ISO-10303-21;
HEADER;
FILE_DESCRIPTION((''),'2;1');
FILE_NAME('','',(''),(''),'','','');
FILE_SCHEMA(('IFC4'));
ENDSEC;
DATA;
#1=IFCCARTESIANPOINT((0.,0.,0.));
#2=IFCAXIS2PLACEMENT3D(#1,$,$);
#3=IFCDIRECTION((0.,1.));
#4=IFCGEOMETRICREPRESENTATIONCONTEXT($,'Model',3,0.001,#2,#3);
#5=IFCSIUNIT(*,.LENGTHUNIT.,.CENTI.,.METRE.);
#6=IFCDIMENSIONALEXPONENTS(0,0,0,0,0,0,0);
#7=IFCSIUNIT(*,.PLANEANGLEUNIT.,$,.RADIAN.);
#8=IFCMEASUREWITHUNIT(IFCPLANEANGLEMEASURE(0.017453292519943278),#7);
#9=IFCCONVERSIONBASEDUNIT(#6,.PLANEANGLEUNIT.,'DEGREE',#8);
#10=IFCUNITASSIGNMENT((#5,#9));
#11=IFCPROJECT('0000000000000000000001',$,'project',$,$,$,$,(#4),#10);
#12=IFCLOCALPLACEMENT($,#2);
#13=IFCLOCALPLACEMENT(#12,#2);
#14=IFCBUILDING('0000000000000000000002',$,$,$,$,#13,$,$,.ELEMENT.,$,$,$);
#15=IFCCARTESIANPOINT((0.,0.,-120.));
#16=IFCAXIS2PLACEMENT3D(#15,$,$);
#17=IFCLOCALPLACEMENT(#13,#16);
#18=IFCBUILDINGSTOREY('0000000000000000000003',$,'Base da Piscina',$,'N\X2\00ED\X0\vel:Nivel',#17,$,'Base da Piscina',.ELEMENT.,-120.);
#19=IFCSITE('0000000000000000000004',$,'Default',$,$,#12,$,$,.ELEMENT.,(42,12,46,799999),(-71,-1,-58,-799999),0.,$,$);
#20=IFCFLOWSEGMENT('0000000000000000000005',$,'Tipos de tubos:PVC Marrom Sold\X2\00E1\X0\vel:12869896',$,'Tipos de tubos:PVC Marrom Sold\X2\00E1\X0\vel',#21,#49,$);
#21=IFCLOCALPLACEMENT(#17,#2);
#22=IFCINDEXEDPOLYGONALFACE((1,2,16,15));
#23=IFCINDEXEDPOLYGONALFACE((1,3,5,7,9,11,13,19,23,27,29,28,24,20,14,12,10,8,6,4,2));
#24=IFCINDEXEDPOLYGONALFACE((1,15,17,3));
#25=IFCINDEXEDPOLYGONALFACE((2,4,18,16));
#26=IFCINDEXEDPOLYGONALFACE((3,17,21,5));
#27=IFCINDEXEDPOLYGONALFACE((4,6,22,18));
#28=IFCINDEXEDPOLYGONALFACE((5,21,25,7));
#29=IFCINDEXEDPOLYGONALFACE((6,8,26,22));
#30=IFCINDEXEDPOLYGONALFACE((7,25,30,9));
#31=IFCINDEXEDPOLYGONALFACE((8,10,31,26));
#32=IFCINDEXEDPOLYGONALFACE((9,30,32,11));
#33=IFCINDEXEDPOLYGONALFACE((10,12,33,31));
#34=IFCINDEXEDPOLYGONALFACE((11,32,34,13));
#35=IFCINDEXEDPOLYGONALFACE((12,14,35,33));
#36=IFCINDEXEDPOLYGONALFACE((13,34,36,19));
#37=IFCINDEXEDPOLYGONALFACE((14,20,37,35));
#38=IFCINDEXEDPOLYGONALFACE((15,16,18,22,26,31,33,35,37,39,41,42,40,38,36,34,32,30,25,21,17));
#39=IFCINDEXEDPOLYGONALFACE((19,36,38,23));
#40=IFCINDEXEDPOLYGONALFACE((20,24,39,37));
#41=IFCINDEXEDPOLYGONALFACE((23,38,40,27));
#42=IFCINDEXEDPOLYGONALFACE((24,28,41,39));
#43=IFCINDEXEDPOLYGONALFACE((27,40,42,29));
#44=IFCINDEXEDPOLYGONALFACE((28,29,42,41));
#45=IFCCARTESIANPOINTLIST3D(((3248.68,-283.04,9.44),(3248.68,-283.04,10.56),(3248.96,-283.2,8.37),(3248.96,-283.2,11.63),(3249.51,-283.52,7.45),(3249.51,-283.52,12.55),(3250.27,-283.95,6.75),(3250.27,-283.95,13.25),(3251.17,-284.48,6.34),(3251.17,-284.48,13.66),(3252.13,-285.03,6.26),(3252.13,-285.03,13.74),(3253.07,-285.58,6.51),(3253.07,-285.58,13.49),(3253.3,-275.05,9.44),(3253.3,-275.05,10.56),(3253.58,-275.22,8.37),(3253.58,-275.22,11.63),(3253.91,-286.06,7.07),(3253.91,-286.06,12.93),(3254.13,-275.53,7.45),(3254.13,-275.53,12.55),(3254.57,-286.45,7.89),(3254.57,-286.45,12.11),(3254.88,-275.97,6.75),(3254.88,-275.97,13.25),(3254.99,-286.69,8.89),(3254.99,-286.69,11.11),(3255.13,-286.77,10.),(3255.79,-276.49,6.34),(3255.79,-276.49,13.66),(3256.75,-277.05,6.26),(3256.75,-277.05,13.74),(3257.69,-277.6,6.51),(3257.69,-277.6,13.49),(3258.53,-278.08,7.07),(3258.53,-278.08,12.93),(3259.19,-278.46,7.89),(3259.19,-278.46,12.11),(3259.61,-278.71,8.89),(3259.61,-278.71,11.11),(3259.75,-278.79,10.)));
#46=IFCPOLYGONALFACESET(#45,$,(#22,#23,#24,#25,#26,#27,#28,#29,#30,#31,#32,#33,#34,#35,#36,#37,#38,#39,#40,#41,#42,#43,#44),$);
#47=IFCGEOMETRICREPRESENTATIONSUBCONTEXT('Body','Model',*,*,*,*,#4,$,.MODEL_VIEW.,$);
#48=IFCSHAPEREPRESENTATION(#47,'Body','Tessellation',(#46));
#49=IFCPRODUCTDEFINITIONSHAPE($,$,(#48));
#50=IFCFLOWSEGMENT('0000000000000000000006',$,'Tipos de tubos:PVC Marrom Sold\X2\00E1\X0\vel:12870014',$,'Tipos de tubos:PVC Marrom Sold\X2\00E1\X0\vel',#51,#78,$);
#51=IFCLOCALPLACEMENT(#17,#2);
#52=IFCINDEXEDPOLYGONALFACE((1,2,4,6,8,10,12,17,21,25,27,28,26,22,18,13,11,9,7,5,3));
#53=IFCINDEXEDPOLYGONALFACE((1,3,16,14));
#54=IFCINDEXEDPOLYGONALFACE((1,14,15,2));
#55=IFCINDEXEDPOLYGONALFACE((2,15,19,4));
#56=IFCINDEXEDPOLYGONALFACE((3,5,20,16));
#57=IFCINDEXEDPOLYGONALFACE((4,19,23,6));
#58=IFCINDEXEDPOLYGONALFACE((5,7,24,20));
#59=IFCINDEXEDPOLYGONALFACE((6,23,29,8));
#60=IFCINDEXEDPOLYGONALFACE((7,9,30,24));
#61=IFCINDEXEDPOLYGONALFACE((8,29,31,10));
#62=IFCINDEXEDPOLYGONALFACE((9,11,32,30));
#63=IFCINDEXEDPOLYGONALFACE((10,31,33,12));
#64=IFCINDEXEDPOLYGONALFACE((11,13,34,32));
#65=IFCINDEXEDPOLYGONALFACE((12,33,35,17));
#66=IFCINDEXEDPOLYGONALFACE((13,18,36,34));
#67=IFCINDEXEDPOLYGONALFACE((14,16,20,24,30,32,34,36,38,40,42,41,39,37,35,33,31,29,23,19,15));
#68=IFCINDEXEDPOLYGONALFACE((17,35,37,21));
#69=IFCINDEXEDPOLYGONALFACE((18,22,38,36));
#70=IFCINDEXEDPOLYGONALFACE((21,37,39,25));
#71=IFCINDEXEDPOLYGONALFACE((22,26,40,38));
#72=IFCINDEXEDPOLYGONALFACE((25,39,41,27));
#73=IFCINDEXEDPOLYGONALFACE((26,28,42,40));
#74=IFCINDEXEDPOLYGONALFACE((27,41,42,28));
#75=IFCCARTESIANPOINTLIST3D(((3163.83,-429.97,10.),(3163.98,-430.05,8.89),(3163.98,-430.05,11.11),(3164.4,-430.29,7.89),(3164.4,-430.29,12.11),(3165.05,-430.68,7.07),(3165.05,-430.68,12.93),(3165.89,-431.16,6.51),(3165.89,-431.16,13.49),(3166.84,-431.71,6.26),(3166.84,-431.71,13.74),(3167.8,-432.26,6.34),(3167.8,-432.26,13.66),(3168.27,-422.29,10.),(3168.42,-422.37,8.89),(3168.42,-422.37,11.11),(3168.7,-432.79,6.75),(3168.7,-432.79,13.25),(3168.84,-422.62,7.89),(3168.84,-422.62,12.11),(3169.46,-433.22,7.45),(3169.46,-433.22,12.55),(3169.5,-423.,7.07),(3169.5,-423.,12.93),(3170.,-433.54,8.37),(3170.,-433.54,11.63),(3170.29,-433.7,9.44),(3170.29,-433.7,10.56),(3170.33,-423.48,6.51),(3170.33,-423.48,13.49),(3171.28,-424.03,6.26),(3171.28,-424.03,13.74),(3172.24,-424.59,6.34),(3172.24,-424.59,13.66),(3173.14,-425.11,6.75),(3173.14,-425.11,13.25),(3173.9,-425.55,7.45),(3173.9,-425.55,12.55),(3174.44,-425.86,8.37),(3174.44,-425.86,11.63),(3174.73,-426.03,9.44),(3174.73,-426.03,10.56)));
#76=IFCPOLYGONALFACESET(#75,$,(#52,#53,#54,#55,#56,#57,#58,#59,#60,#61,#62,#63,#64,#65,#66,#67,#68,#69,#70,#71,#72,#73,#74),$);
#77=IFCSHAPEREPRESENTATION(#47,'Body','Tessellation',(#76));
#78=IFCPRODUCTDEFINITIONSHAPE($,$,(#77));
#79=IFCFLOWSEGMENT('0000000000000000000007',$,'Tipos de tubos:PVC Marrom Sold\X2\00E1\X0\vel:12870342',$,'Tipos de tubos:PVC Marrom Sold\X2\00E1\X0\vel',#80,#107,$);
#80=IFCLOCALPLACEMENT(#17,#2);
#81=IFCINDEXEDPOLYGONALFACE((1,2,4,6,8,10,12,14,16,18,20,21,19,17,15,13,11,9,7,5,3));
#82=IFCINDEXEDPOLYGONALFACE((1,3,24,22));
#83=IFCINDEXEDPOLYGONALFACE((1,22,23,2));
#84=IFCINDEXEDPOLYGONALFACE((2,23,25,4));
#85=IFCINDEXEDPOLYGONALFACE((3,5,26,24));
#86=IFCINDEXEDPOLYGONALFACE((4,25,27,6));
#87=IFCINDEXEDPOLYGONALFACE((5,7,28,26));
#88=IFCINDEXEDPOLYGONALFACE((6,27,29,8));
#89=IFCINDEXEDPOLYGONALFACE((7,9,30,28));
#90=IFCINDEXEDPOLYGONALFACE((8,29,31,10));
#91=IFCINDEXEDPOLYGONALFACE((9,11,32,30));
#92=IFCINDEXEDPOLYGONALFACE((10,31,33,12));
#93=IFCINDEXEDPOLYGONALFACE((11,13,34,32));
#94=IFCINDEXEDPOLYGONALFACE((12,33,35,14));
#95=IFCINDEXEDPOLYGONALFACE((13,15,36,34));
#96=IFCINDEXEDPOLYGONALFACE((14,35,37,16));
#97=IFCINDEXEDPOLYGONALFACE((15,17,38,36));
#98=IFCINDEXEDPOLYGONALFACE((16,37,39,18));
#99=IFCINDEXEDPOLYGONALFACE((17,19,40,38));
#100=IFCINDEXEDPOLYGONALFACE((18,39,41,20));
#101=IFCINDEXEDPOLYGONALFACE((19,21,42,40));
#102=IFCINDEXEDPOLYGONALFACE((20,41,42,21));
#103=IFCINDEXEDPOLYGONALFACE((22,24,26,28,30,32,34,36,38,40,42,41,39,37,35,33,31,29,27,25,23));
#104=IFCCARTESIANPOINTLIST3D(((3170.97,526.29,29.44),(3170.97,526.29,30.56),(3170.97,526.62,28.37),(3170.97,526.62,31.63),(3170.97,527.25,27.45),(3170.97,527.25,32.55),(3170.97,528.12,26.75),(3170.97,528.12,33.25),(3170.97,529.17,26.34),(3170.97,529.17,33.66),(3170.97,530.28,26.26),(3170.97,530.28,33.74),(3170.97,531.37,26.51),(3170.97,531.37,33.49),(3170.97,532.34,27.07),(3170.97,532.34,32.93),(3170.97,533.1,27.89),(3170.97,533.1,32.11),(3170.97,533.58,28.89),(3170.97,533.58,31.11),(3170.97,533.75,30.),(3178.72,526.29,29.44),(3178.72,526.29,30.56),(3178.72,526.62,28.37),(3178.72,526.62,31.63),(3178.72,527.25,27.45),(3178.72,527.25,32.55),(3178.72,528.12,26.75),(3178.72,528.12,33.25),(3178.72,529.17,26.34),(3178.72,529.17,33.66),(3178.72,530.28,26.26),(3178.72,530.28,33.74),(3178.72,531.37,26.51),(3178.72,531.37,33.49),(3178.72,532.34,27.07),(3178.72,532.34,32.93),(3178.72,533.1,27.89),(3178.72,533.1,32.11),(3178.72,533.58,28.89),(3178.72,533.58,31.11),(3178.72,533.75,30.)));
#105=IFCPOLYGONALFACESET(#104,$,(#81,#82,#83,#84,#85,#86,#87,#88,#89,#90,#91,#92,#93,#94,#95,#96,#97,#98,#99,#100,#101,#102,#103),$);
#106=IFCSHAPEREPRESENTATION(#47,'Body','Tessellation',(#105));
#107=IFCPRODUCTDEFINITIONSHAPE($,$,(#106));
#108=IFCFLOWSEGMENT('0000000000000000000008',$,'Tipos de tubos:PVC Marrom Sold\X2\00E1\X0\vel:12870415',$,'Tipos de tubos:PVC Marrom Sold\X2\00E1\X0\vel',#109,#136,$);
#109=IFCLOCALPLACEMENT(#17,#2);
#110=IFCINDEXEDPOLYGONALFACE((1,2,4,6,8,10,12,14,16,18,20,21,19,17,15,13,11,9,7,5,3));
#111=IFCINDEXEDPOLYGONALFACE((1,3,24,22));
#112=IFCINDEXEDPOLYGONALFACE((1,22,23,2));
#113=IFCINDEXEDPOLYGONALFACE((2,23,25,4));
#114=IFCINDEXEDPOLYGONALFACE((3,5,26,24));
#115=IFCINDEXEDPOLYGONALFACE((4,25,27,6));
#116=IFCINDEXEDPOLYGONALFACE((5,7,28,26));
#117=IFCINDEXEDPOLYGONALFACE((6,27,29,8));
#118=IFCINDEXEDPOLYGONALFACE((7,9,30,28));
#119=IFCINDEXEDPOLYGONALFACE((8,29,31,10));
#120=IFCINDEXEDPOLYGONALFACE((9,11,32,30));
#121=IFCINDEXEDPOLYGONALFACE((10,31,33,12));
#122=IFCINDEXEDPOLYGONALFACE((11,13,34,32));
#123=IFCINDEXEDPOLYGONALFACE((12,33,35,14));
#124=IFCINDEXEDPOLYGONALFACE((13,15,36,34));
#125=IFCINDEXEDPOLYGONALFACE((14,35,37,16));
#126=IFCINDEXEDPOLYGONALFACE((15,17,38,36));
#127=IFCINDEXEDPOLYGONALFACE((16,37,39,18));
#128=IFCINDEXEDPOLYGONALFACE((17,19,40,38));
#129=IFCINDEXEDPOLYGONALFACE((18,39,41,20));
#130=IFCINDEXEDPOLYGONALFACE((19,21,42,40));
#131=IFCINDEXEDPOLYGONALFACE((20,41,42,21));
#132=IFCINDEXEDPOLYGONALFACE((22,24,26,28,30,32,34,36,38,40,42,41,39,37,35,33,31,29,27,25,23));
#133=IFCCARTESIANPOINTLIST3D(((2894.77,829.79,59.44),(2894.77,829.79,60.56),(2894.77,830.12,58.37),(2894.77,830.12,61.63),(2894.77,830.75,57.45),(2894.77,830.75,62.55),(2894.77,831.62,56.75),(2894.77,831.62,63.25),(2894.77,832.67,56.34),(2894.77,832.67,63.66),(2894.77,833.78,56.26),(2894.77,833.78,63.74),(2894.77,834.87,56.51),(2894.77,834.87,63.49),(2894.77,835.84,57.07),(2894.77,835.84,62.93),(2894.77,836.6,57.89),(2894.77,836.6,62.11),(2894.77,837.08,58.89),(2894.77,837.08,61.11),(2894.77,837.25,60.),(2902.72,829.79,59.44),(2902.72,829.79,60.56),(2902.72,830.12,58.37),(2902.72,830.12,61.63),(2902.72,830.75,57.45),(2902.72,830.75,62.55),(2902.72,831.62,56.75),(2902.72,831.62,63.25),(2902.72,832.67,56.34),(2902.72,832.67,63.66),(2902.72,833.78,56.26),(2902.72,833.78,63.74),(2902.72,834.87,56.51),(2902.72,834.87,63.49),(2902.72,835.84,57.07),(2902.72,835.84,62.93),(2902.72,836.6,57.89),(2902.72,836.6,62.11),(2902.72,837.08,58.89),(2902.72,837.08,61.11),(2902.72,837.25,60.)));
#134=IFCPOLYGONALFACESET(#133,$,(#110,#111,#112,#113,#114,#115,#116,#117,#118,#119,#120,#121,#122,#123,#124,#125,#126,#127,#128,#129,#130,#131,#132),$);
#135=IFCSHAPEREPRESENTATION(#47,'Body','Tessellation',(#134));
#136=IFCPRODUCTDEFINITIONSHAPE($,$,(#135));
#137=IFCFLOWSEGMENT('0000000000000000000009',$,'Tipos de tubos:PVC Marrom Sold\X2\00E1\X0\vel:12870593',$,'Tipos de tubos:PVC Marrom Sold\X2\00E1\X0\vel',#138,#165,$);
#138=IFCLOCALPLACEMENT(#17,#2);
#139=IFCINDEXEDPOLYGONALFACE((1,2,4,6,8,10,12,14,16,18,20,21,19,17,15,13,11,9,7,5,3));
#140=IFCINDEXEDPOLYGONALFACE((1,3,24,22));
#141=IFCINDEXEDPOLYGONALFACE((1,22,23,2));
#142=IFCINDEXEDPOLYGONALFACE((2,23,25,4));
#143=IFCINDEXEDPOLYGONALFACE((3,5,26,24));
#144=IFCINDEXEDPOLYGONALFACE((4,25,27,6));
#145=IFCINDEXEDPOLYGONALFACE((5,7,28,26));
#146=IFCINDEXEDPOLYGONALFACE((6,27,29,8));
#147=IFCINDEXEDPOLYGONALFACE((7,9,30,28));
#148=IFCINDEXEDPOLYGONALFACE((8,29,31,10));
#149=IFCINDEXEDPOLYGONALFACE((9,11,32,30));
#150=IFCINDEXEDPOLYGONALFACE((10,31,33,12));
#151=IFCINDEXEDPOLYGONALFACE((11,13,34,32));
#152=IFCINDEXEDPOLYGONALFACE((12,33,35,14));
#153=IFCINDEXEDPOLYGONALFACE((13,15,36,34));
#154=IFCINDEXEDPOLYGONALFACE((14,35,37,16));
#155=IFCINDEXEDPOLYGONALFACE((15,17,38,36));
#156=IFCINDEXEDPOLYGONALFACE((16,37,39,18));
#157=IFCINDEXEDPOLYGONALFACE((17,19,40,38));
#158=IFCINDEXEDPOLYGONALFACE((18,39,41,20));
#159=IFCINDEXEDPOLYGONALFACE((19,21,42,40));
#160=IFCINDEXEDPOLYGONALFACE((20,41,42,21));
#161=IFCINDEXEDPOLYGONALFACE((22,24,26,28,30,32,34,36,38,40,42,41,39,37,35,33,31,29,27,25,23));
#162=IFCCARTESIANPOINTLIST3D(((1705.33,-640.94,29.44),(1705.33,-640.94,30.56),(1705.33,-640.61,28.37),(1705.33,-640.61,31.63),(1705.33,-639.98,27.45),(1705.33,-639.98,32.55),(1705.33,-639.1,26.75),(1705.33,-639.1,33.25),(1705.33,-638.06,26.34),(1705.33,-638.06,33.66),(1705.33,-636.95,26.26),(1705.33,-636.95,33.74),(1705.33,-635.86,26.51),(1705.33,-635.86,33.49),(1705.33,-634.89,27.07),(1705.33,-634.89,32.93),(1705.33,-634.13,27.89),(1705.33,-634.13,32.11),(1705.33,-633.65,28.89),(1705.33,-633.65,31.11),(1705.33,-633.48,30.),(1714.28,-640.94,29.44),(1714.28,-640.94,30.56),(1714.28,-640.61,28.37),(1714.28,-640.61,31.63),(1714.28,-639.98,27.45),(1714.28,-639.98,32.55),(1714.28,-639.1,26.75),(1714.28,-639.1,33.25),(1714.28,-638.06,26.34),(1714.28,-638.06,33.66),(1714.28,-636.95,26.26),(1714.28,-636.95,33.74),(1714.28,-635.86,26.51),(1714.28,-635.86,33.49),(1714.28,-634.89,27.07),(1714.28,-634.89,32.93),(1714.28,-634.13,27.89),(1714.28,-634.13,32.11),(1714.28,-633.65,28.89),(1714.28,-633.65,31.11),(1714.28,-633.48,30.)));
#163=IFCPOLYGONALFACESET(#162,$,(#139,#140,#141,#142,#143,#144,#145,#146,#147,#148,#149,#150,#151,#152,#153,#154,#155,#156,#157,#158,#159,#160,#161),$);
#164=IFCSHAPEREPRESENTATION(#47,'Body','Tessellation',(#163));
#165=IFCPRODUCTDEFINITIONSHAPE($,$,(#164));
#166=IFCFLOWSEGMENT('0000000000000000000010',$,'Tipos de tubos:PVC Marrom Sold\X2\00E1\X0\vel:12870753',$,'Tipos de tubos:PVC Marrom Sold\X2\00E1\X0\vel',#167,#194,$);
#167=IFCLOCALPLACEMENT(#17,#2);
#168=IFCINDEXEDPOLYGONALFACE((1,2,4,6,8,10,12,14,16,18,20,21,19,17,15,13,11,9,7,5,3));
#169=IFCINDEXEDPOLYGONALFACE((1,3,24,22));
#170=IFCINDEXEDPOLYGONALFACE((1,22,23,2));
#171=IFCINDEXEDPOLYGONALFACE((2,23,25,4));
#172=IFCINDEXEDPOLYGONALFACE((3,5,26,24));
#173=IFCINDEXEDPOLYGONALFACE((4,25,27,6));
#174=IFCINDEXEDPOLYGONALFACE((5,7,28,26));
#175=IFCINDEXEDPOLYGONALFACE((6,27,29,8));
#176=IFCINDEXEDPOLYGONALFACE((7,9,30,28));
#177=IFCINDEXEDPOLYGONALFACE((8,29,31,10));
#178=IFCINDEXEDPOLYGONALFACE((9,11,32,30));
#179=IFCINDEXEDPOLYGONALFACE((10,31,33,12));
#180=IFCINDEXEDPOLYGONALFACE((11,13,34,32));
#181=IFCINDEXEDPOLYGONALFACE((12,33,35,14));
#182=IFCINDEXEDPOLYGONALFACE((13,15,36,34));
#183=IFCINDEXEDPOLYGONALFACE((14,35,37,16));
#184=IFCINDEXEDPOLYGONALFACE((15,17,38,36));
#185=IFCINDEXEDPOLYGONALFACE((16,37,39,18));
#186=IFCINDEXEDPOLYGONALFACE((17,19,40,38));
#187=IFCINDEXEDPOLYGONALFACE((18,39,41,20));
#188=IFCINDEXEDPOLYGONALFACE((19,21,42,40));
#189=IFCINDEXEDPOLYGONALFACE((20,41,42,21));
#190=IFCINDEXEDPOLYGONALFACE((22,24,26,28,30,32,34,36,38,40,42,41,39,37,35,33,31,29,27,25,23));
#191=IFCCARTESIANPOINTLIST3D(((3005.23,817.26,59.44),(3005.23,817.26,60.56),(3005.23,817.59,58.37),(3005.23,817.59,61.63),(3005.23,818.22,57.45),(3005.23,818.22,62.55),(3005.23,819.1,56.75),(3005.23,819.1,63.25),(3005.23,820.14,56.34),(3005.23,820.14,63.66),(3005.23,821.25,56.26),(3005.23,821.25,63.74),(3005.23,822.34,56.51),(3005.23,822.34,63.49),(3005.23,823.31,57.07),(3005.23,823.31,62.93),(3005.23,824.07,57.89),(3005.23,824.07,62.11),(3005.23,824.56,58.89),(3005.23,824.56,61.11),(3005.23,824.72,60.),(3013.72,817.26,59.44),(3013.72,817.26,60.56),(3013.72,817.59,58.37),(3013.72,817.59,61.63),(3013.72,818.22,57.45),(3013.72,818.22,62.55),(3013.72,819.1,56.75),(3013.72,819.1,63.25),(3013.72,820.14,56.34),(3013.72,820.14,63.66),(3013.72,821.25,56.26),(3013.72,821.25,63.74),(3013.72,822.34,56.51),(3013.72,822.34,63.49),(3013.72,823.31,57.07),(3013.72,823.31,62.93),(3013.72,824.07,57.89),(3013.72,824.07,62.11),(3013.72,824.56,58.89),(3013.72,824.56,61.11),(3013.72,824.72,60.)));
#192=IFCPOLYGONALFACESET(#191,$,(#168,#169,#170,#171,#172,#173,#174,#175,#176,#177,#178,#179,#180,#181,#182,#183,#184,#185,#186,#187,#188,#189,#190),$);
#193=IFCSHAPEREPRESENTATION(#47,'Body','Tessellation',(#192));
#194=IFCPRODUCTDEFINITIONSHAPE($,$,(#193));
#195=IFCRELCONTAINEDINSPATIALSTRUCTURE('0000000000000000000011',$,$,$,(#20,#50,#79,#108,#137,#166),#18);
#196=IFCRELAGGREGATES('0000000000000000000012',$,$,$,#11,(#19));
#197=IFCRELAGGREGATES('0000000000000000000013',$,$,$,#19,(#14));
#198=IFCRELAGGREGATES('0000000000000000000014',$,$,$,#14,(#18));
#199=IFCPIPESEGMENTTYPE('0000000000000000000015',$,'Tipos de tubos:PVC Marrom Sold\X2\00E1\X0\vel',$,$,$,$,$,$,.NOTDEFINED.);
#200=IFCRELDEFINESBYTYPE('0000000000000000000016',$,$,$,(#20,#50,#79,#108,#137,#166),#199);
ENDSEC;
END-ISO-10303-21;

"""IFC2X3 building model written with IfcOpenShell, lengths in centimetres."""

from ifc_helpers import new_model, entity, si_unit, converted_unit, direction, frame, frame_2d, origin, origin_2d_with_axis, place, context, subcontext, project, spatial, circle, extrude, type_object, element, save


model = new_model("IFC2X3")

# Units and contexts
model_context = context("Model", 3, precision=0.001, world=origin(), true_north=direction((0.0, 1.0)))
body_context = subcontext(model_context, "Body", "Model", "MODEL_VIEW")
ifc_project = project(units=[si_unit("LENGTHUNIT", "METRE", prefix="CENTI"), converted_unit("PLANEANGLEUNIT", "DEGREE", entity("IfcPlaneAngleMeasure", 0.017453292519943278), si_unit("PLANEANGLEUNIT", "RADIAN"), dimensions=[0, 0, 0, 0, 0, 0, 0])], contexts=[model_context])

# Site, building, storey
site_placement = place(None, origin())
site = spatial("IfcSite", under=ifc_project, at=site_placement, Name="Default", CompositionType="ELEMENT", RefLatitude=(42, 12, 46, 799999), RefLongitude=(-71, -1, -58, -799999), RefElevation=0.0)
building_placement = place(site_placement, origin())
building = spatial("IfcBuilding", under=site, at=building_placement, CompositionType="ELEMENT")
storey_placement = place(building_placement, frame((0.0, 0.0, -120.0)))
storey = spatial("IfcBuildingStorey", under=building, at=storey_placement, Name="Base da Piscina", ObjectType="Nível:Nivel", LongName="Base da Piscina", CompositionType="ELEMENT", Elevation=-120.0)

# Flow segments
pipe_segment_type = type_object("IfcPipeSegmentType", Name="Tipos de tubos:PVC Marrom Soldável", PredefinedType="NOTDEFINED")
flow_segment_1_placement = place(storey_placement, origin())
element("IfcFlowSegment", 1, at=flow_segment_1_placement, inside=storey, type_object=pipe_segment_type, Name="Tipos de tubos:PVC Marrom Soldável:12869896", ObjectType="Tipos de tubos:PVC Marrom Soldável", context=body_context, shape_type="SweptSolid", body=[
    extrude(circle(Radius=3.75, at=frame_2d((0.0, 0.0), x_axis=(1.0, 0.0))), frame((3251.89, -284.89, 10.0), z_axis=(0.50079, 0.865569, 0.0), x_axis=(0.865569, -0.50079, 0.0)), (0.0, 0.0, 1.0), 9.22),
])
flow_segment_2_placement = place(storey_placement, origin())
element("IfcFlowSegment", 2, at=flow_segment_2_placement, inside=storey, type_object=pipe_segment_type, Name="Tipos de tubos:PVC Marrom Soldável:12870014", ObjectType="Tipos de tubos:PVC Marrom Soldável", context=body_context, shape_type="SweptSolid", body=[
    extrude(circle(Radius=3.75, at=origin_2d_with_axis()), frame((3167.08, -431.85, 10.0), z_axis=(0.50079, 0.865569, 0.0), x_axis=(-0.865569, 0.50079, 0.0)), (0.0, 0.0, 1.0), 8.87),
])
flow_segment_3_placement = place(storey_placement, origin())
element("IfcFlowSegment", 3, at=flow_segment_3_placement, inside=storey, type_object=pipe_segment_type, Name="Tipos de tubos:PVC Marrom Soldável:12870342", ObjectType="Tipos de tubos:PVC Marrom Soldável", context=body_context, shape_type="SweptSolid", body=[
    extrude(circle(Radius=3.75, at=frame_2d((0.0, 0.0), x_axis=(1.0, 0.0))), frame((3170.97, 530.0, 30.0), z_axis=(1.0, 0.0, 0.0), x_axis=(0.0, 1.0, 0.0)), (0.0, 0.0, 1.0), 7.75),
])
flow_segment_4_placement = place(storey_placement, origin())
element("IfcFlowSegment", 4, at=flow_segment_4_placement, inside=storey, type_object=pipe_segment_type, Name="Tipos de tubos:PVC Marrom Soldável:12870415", ObjectType="Tipos de tubos:PVC Marrom Soldável", context=body_context, shape_type="SweptSolid", body=[
    extrude(circle(Radius=3.75, at=origin_2d_with_axis()), frame((2894.77, 833.5, 60.0), z_axis=(1.0, 0.0, 0.0), x_axis=(0.0, 1.0, 0.0)), (0.0, 0.0, 1.0), 7.95),
])
flow_segment_5_placement = place(storey_placement, origin())
element("IfcFlowSegment", 5, at=flow_segment_5_placement, inside=storey, type_object=pipe_segment_type, Name="Tipos de tubos:PVC Marrom Soldável:12870593", ObjectType="Tipos de tubos:PVC Marrom Soldável", context=body_context, shape_type="SweptSolid", body=[
    extrude(circle(Radius=3.75, at=frame_2d((0.0, 0.0), x_axis=(1.0, 0.0))), frame((1705.33, -637.23, 30.0), z_axis=(1.0, 0.0, 0.0), x_axis=(0.0, 1.0, 0.0)), (0.0, 0.0, 1.0), 8.95),
])
flow_segment_6_placement = place(storey_placement, origin())
element("IfcFlowSegment", 6, at=flow_segment_6_placement, inside=storey, type_object=pipe_segment_type, Name="Tipos de tubos:PVC Marrom Soldável:12870753", ObjectType="Tipos de tubos:PVC Marrom Soldável", context=body_context, shape_type="SweptSolid", body=[
    extrude(circle(Radius=3.75, at=origin_2d_with_axis()), frame((3005.23, 820.97, 60.0), z_axis=(1.0, 0.0, 0.0), x_axis=(0.0, 1.0, 0.0)), (0.0, 0.0, 1.0), 8.5),
])

save(model, "model.ifc")
